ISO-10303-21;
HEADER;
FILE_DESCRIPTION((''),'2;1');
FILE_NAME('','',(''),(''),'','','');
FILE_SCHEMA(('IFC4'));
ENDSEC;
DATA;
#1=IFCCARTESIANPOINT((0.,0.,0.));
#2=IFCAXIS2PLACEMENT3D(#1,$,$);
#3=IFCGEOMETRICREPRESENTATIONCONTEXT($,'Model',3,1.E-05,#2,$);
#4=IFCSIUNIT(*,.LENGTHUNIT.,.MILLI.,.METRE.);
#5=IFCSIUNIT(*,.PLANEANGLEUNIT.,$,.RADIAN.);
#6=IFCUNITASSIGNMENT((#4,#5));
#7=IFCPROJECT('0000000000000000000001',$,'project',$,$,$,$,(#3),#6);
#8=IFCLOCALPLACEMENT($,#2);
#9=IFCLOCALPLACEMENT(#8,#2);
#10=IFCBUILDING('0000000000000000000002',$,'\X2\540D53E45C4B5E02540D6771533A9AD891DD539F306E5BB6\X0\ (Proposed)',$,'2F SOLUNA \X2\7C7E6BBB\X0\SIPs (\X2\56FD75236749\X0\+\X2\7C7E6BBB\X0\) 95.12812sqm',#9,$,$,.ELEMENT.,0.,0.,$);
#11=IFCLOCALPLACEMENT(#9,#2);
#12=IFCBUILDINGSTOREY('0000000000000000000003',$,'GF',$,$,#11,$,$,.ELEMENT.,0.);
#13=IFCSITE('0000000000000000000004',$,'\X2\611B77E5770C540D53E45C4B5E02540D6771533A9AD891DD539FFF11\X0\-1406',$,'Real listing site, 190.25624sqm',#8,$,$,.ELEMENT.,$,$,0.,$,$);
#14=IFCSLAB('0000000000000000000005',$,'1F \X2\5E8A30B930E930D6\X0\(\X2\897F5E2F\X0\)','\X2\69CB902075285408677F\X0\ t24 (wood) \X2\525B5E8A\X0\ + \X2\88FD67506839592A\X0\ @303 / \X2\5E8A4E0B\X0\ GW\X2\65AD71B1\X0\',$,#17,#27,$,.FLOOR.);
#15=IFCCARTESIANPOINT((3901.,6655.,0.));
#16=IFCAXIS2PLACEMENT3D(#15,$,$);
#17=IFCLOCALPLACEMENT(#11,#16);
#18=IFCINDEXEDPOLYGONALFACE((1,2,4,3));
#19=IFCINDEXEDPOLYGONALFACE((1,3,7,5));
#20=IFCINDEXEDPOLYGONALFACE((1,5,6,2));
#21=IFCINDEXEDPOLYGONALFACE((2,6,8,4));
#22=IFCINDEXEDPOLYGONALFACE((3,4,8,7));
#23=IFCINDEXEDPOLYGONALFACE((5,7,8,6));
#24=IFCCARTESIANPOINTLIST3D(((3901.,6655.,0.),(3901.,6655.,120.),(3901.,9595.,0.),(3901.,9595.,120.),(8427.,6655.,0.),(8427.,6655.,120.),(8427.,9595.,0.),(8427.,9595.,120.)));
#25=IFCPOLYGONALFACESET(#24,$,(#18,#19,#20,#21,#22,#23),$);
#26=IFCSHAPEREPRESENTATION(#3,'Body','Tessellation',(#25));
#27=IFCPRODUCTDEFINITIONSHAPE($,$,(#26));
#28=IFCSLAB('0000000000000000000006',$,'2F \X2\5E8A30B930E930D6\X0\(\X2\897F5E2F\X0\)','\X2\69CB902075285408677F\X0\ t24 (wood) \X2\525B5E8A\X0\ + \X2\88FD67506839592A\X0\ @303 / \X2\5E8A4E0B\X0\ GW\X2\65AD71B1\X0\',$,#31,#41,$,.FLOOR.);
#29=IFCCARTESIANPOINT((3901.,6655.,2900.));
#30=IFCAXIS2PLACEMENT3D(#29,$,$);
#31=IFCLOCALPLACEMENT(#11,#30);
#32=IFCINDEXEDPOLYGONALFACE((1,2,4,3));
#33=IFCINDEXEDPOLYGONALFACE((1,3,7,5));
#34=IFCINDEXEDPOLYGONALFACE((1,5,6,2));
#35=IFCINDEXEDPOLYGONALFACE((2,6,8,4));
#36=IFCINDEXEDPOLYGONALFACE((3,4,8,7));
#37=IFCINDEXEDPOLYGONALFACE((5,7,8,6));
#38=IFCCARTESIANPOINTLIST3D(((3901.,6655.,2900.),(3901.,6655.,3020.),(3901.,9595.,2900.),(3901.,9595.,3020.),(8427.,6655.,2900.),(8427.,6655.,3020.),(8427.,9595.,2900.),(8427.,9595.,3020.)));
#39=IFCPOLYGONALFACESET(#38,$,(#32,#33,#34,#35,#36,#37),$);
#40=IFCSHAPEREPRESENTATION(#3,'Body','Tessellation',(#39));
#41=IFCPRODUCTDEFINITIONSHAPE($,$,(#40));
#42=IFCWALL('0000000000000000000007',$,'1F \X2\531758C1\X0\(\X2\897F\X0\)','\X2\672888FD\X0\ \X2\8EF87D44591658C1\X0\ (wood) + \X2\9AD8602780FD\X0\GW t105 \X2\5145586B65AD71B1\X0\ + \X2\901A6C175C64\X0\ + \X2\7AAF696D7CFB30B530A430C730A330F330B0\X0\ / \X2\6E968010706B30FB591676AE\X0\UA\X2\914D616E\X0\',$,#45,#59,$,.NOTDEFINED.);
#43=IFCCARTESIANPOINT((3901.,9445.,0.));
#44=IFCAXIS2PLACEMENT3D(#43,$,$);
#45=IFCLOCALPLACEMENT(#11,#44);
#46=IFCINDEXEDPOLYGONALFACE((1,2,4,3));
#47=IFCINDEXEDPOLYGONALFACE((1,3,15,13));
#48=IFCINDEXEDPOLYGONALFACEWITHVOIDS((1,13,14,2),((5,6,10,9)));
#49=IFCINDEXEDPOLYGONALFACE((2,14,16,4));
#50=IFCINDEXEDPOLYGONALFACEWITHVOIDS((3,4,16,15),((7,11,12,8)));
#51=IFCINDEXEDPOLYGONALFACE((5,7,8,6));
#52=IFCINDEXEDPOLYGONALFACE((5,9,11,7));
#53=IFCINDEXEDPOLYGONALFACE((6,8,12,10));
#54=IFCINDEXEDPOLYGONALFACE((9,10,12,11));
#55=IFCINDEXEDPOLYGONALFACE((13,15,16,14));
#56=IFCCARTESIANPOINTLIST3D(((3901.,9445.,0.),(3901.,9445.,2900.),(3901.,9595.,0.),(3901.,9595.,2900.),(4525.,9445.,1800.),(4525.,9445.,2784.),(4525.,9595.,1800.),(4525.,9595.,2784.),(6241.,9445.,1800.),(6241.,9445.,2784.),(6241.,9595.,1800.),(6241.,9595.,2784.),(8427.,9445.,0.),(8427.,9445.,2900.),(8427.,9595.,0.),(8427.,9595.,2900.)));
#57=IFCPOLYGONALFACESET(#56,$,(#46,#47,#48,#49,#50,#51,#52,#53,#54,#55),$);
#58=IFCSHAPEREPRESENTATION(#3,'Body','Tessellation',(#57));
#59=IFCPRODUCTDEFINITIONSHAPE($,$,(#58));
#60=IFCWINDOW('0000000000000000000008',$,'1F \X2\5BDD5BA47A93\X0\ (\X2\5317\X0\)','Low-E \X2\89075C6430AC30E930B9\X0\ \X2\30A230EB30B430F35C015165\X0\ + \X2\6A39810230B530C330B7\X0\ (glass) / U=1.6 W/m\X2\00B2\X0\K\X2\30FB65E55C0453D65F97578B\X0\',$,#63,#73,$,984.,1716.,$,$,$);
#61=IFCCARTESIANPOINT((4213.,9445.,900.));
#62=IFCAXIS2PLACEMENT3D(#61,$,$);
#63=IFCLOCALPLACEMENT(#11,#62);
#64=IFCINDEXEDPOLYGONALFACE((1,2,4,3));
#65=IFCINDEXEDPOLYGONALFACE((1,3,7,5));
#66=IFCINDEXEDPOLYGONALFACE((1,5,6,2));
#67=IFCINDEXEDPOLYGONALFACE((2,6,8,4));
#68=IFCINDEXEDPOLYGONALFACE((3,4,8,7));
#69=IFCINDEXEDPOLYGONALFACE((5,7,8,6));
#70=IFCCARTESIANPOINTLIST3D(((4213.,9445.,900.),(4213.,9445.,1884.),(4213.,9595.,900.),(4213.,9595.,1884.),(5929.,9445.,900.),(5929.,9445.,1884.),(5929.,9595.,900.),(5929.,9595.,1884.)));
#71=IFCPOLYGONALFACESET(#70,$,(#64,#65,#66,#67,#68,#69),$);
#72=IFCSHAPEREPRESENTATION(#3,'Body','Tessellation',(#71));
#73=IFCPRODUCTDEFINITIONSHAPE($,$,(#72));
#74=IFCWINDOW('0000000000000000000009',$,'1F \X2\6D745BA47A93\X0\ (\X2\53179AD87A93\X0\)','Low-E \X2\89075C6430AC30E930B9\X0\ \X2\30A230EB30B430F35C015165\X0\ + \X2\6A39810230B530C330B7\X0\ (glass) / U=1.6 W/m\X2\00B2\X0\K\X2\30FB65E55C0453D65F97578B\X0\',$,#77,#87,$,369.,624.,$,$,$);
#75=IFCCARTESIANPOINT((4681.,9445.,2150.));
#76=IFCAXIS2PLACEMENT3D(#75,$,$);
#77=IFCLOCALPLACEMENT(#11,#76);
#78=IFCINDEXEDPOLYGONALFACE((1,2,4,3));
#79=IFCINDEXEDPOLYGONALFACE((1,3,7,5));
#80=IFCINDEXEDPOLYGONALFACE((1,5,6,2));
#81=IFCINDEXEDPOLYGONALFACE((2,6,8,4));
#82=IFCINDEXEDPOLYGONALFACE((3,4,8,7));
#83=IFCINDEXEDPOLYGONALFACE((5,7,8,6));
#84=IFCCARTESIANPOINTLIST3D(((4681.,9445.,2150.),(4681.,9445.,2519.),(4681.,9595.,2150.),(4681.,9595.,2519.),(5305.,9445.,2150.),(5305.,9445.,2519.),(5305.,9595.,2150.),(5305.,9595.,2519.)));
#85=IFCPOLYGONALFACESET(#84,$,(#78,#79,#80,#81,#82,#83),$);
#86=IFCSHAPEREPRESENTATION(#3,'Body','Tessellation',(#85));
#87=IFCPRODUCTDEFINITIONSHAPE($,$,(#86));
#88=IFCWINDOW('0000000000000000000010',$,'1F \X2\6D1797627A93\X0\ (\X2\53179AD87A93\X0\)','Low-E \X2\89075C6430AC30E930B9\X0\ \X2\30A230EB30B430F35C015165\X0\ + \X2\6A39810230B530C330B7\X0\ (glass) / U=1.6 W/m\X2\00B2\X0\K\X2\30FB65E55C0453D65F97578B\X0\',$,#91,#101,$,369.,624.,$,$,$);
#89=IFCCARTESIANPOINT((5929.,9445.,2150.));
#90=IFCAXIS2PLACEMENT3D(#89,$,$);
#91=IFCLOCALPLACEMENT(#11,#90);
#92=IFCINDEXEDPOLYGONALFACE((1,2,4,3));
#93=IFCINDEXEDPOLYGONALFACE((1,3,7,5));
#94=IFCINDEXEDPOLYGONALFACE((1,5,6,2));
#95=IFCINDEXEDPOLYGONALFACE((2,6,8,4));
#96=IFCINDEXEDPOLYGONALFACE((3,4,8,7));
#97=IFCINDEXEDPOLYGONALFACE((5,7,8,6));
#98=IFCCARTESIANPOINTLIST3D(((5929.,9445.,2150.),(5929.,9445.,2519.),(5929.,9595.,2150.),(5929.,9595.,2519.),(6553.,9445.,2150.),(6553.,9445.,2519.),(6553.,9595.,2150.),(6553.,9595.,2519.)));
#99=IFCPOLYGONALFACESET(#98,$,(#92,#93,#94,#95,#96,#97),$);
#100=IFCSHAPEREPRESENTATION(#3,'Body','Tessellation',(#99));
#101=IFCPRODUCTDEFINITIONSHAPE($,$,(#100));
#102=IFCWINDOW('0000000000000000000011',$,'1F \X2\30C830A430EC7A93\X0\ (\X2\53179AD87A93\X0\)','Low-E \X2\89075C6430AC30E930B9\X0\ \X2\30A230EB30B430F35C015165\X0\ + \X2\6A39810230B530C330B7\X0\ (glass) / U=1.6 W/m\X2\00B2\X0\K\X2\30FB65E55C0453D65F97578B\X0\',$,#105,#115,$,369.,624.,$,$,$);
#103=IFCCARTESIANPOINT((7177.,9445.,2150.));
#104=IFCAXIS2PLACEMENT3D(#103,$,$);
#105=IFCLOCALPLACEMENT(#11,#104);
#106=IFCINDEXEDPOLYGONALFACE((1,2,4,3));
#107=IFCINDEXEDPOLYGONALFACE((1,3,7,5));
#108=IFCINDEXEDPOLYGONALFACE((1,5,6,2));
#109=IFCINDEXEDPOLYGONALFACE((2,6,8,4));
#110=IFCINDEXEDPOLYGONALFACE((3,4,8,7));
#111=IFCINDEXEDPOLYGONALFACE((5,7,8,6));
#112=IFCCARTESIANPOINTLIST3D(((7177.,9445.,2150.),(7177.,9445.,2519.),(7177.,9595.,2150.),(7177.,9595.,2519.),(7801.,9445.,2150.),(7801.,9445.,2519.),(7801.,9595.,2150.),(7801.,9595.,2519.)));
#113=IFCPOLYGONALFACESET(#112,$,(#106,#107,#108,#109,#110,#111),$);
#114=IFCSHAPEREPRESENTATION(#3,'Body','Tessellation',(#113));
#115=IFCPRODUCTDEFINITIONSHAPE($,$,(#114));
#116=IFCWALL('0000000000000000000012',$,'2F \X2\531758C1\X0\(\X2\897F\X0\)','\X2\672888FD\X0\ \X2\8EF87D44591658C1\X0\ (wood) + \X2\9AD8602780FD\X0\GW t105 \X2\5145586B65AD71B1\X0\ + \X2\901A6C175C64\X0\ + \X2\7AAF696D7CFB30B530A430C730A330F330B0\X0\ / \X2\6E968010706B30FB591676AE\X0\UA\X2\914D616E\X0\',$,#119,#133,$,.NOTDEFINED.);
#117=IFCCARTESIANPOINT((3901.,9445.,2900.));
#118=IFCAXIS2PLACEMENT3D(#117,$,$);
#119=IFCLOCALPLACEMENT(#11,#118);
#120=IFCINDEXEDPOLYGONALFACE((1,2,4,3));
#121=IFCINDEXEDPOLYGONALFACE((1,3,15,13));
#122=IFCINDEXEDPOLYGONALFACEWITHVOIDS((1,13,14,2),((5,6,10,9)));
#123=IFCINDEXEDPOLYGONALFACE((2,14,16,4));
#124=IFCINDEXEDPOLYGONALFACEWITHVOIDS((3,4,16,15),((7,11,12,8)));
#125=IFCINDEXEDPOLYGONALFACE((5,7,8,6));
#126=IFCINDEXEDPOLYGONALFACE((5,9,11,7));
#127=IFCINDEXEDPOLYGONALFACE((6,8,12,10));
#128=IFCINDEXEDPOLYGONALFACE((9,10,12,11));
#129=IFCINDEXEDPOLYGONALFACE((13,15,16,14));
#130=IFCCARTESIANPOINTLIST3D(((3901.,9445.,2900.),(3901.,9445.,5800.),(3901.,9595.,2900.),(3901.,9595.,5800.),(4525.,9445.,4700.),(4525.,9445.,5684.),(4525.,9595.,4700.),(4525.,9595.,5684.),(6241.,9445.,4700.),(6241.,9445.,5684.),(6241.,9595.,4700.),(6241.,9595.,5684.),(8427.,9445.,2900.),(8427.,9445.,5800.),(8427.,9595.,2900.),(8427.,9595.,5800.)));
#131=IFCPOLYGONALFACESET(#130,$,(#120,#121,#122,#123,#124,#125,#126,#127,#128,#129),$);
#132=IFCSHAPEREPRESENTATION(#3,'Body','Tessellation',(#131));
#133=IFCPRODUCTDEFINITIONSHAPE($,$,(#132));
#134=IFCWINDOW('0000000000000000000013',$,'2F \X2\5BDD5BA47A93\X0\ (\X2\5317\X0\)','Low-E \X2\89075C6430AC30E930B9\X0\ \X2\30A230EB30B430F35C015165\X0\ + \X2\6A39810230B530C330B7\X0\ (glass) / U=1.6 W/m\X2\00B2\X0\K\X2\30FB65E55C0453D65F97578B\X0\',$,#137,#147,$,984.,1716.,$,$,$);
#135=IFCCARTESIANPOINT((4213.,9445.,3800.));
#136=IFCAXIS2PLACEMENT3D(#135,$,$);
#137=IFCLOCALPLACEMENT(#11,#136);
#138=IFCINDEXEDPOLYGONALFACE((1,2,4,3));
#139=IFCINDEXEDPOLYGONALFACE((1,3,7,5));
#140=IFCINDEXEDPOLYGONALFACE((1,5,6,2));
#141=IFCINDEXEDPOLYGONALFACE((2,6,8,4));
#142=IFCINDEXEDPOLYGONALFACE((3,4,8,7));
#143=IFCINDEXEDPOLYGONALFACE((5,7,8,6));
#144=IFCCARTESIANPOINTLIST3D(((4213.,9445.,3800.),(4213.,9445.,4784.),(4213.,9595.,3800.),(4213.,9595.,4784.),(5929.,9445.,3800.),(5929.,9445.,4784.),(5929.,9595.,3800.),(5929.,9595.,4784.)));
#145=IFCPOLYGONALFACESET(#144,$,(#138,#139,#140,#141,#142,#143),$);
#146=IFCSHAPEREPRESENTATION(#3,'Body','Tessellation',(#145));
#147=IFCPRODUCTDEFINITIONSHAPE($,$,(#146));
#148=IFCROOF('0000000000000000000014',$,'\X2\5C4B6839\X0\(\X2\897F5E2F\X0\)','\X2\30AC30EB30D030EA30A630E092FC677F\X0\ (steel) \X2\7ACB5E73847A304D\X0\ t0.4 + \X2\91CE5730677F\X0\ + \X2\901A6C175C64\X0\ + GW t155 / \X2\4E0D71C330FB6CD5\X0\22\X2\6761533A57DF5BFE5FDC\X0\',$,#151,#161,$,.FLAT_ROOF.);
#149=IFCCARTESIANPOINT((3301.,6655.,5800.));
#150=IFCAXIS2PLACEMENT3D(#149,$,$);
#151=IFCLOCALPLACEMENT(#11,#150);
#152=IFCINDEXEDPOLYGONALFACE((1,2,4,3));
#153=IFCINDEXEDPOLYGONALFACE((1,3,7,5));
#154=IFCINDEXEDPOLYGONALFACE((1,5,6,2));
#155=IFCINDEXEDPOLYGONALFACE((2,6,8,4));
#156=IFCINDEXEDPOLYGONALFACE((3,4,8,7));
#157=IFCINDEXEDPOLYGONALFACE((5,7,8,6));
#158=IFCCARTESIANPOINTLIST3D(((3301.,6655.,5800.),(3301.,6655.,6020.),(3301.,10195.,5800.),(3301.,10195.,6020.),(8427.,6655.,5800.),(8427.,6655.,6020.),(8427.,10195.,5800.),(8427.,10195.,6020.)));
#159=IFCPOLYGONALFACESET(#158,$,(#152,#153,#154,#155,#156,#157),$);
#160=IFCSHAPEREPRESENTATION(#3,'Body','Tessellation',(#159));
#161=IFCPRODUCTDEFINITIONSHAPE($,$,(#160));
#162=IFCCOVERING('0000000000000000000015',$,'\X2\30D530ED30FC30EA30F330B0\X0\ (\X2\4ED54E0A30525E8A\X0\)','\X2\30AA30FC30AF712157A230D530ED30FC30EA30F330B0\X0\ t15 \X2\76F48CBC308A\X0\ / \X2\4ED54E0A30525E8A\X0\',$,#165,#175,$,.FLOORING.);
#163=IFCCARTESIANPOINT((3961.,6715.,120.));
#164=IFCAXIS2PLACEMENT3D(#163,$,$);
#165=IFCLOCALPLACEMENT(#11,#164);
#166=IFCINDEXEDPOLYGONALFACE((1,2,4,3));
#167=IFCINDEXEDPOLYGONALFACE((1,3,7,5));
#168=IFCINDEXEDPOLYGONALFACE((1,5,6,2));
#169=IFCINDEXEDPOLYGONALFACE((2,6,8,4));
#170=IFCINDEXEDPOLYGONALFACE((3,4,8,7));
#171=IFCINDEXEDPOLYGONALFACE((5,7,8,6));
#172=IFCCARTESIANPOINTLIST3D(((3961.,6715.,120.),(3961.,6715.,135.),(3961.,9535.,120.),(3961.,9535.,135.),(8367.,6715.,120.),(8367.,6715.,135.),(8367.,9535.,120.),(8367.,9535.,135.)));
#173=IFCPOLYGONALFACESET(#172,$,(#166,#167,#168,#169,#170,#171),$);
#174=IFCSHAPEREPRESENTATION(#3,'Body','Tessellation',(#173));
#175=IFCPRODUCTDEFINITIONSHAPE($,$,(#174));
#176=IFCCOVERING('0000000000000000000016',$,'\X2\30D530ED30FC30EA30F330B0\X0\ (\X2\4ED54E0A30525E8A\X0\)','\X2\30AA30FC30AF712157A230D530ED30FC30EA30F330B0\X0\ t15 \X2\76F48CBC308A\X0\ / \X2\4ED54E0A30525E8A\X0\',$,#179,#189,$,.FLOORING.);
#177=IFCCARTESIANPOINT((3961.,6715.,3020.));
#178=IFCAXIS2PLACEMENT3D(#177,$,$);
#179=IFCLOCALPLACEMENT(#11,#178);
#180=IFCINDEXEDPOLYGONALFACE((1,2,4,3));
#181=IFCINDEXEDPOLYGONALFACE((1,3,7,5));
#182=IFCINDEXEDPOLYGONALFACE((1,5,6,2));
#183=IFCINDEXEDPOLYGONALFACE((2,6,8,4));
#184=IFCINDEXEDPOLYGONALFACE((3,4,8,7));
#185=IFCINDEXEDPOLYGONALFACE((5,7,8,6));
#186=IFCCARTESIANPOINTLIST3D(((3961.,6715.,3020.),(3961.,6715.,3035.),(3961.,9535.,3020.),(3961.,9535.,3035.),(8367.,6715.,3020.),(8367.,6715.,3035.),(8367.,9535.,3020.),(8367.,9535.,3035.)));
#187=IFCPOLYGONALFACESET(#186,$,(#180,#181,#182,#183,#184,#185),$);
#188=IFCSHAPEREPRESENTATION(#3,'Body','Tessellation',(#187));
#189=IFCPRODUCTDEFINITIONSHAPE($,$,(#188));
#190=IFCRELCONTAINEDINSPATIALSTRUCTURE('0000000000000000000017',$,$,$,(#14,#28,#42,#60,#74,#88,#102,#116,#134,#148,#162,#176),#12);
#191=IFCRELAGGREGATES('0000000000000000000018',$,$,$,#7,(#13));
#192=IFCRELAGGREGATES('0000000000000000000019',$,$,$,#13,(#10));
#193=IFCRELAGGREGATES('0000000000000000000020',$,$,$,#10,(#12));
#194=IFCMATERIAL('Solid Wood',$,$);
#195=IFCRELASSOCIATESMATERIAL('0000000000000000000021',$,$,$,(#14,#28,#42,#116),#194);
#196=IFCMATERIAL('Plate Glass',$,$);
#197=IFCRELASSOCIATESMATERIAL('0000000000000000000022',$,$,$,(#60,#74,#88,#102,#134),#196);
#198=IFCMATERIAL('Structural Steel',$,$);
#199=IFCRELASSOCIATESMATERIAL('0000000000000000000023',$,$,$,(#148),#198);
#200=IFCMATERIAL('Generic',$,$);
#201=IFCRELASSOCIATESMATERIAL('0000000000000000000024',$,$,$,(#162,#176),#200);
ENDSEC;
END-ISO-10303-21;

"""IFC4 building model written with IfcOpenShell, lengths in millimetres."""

from ifc_helpers import new_model, si_unit, frame, frame_2d, origin, place, context, project, spatial, rectangle, extrude, material, element, fill, save


model = new_model("IFC4")

# Units and contexts
model_context = context("Model", 3, precision=1e-05, world=origin())
ifc_project = project(units=[si_unit("LENGTHUNIT", "METRE", prefix="MILLI"), si_unit("PLANEANGLEUNIT", "RADIAN")], contexts=[model_context])

# Site, building, storey
site_placement = place(None, origin())
site = spatial("IfcSite", under=ifc_project, at=site_placement, Name="愛知県名古屋市名東区高針原１-1406", ObjectType="Real listing site, 190.25624sqm", CompositionType="ELEMENT", RefElevation=0.0)
building_placement = place(site_placement, origin())
building = spatial("IfcBuilding", under=site, at=building_placement, Name="名古屋市名東区高針原の家 (Proposed)", ObjectType="2F SOLUNA 籾殻SIPs (国産杉+籾殻) 95.12812sqm", CompositionType="ELEMENT", ElevationOfRefHeight=0.0, ElevationOfTerrain=0.0)
storey_placement = place(building_placement, origin())
storey = spatial("IfcBuildingStorey", under=building, at=storey_placement, Name="GF", CompositionType="ELEMENT", Elevation=0.0)

# Slabs
ifc_material_1 = material(Name="Solid Wood")
slab_1_placement = place(storey_placement, frame((3901.0, 6655.0, 0.0)))
element("IfcSlab", 1, at=slab_1_placement, inside=storey, material=ifc_material_1, Name="1F 床スラブ(西帯)", Description="構造用合板 t24 (wood) 剛床 + 製材根太 @303 / 床下 GW断熱", PredefinedType="FLOOR", context=model_context, shape_type="SweptSolid", body=[
    extrude(rectangle(XDim=4526.0, YDim=2940.0, at=frame_2d((2263.0, 1470.0))), frame((3901.0, 6655.0, 0.0)), (0.0, 0.0, 1.0), 120.0),
])
slab_2_placement = place(storey_placement, frame((3901.0, 6655.0, 2900.0)))
element("IfcSlab", 2, at=slab_2_placement, inside=storey, material=ifc_material_1, Name="2F 床スラブ(西帯)", Description="構造用合板 t24 (wood) 剛床 + 製材根太 @303 / 床下 GW断熱", PredefinedType="FLOOR", context=model_context, shape_type="SweptSolid", body=[
    extrude(rectangle(XDim=4526.0, YDim=2940.0, at=frame_2d((2263.0, 1470.0))), frame((3901.0, 6655.0, 2900.0)), (0.0, 0.0, 1.0), 120.0),
])

# Wall, openings, windows
wall_1_placement = place(storey_placement, frame((3901.0, 9445.0, 0.0)))
wall_1 = element("IfcWall", 3, at=wall_1_placement, inside=storey, material=ifc_material_1, Name="1F 北壁(西)", Description="木製 軸組外壁 (wood) + 高性能GW t105 充填断熱 + 通気層 + 窯業系サイディング / 準耐火・外皮UA配慮", PredefinedType="NOTDEFINED", context=model_context, shape_type="SweptSolid", body=[
    extrude(rectangle(XDim=4526.0, YDim=150.0, at=frame_2d((2263.0, 75.0))), frame((3901.0, 9445.0, 0.0)), (0.0, 0.0, 1.0), 2900.0),
])
opening_1_placement = place(storey_placement, frame((4213.0, 9445.0, 900.0)))
opening_1 = element("IfcOpeningElement", 4, at=opening_1_placement, cuts=wall_1, PredefinedType="NOTDEFINED", context=model_context, shape_type="SweptSolid", body=[
    extrude(rectangle(XDim=1716.0, YDim=150.0, at=frame_2d((858.0, 75.0))), frame((4213.0, 9445.0, 900.0)), (0.0, 0.0, 1.0), 984.0),
])
opening_2_placement = place(storey_placement, frame((4681.0, 9445.0, 2150.0)))
opening_2 = element("IfcOpeningElement", 5, at=opening_2_placement, cuts=wall_1, PredefinedType="NOTDEFINED", context=model_context, shape_type="SweptSolid", body=[
    extrude(rectangle(XDim=624.0, YDim=150.0, at=frame_2d((312.0, 75.0))), frame((4681.0, 9445.0, 2150.0)), (0.0, 0.0, 1.0), 369.0),
])
opening_3_placement = place(storey_placement, frame((5929.0, 9445.0, 2150.0)))
opening_3 = element("IfcOpeningElement", 6, at=opening_3_placement, cuts=wall_1, PredefinedType="NOTDEFINED", context=model_context, shape_type="SweptSolid", body=[
    extrude(rectangle(XDim=624.0, YDim=150.0, at=frame_2d((312.0, 75.0))), frame((5929.0, 9445.0, 2150.0)), (0.0, 0.0, 1.0), 369.0),
])
opening_4_placement = place(storey_placement, frame((7177.0, 9445.0, 2150.0)))
opening_4 = element("IfcOpeningElement", 7, at=opening_4_placement, cuts=wall_1, PredefinedType="NOTDEFINED", context=model_context, shape_type="SweptSolid", body=[
    extrude(rectangle(XDim=624.0, YDim=150.0, at=frame_2d((312.0, 75.0))), frame((7177.0, 9445.0, 2150.0)), (0.0, 0.0, 1.0), 369.0),
])
ifc_material_2 = material(Name="Plate Glass")
window_1_placement = place(storey_placement, frame((4213.0, 9445.0, 900.0)))
window_1 = element("IfcWindow", 8, at=window_1_placement, inside=storey, material=ifc_material_2, Name="1F 寝室窓 (北)", Description="Low-E 複層ガラス アルゴン封入 + 樹脂サッシ (glass) / U=1.6 W/m²K・日射取得型", OverallHeight=984.0, OverallWidth=1716.0, context=model_context, shape_type="SweptSolid", body=[
    extrude(rectangle(XDim=1716.0, YDim=150.0, at=frame_2d((858.0, 75.0))), frame((4213.0, 9445.0, 900.0)), (0.0, 0.0, 1.0), 984.0),
])
fill(opening_1, window_1)
window_2_placement = place(storey_placement, frame((4681.0, 9445.0, 2150.0)))
window_2 = element("IfcWindow", 9, at=window_2_placement, inside=storey, material=ifc_material_2, Name="1F 浴室窓 (北高窓)", Description="Low-E 複層ガラス アルゴン封入 + 樹脂サッシ (glass) / U=1.6 W/m²K・日射取得型", OverallHeight=369.0, OverallWidth=624.0, context=model_context, shape_type="SweptSolid", body=[
    extrude(rectangle(XDim=624.0, YDim=150.0, at=frame_2d((312.0, 75.0))), frame((4681.0, 9445.0, 2150.0)), (0.0, 0.0, 1.0), 369.0),
])
fill(opening_2, window_2)
window_3_placement = place(storey_placement, frame((5929.0, 9445.0, 2150.0)))
window_3 = element("IfcWindow", 10, at=window_3_placement, inside=storey, material=ifc_material_2, Name="1F 洗面窓 (北高窓)", Description="Low-E 複層ガラス アルゴン封入 + 樹脂サッシ (glass) / U=1.6 W/m²K・日射取得型", OverallHeight=369.0, OverallWidth=624.0, context=model_context, shape_type="SweptSolid", body=[
    extrude(rectangle(XDim=624.0, YDim=150.0, at=frame_2d((312.0, 75.0))), frame((5929.0, 9445.0, 2150.0)), (0.0, 0.0, 1.0), 369.0),
])
fill(opening_3, window_3)
window_4_placement = place(storey_placement, frame((7177.0, 9445.0, 2150.0)))
window_4 = element("IfcWindow", 11, at=window_4_placement, inside=storey, material=ifc_material_2, Name="1F トイレ窓 (北高窓)", Description="Low-E 複層ガラス アルゴン封入 + 樹脂サッシ (glass) / U=1.6 W/m²K・日射取得型", OverallHeight=369.0, OverallWidth=624.0, context=model_context, shape_type="SweptSolid", body=[
    extrude(rectangle(XDim=624.0, YDim=150.0, at=frame_2d((312.0, 75.0))), frame((7177.0, 9445.0, 2150.0)), (0.0, 0.0, 1.0), 369.0),
])
fill(opening_4, window_4)

# Wall, opening, window
wall_2_placement = place(storey_placement, frame((3901.0, 9445.0, 2900.0)))
wall_2 = element("IfcWall", 12, at=wall_2_placement, inside=storey, material=ifc_material_1, Name="2F 北壁(西)", Description="木製 軸組外壁 (wood) + 高性能GW t105 充填断熱 + 通気層 + 窯業系サイディング / 準耐火・外皮UA配慮", PredefinedType="NOTDEFINED", context=model_context, shape_type="SweptSolid", body=[
    extrude(rectangle(XDim=4526.0, YDim=150.0, at=frame_2d((2263.0, 75.0))), frame((3901.0, 9445.0, 2900.0)), (0.0, 0.0, 1.0), 2900.0),
])
opening_5_placement = place(storey_placement, frame((4213.0, 9445.0, 3800.0)))
opening_5 = element("IfcOpeningElement", 13, at=opening_5_placement, cuts=wall_2, PredefinedType="NOTDEFINED", context=model_context, shape_type="SweptSolid", body=[
    extrude(rectangle(XDim=1716.0, YDim=150.0, at=frame_2d((858.0, 75.0))), frame((4213.0, 9445.0, 3800.0)), (0.0, 0.0, 1.0), 984.0),
])
window_5_placement = place(storey_placement, frame((4213.0, 9445.0, 3800.0)))
window_5 = element("IfcWindow", 14, at=window_5_placement, inside=storey, material=ifc_material_2, Name="2F 寝室窓 (北)", Description="Low-E 複層ガラス アルゴン封入 + 樹脂サッシ (glass) / U=1.6 W/m²K・日射取得型", OverallHeight=984.0, OverallWidth=1716.0, context=model_context, shape_type="SweptSolid", body=[
    extrude(rectangle(XDim=1716.0, YDim=150.0, at=frame_2d((858.0, 75.0))), frame((4213.0, 9445.0, 3800.0)), (0.0, 0.0, 1.0), 984.0),
])
fill(opening_5, window_5)

# Roof
ifc_material_3 = material(Name="Structural Steel")
for number, where, name in (
    (15, (3301.0, 6655.0, 5800.0), "屋根(西帯)"),
):
    element("IfcRoof", number, at=place(storey_placement, frame(where)), inside=storey, material=ifc_material_3, Name=name, Description="ガルバリウム鋼板 (steel) 立平葺き t0.4 + 野地板 + 通気層 + GW t155 / 不燃・法22条区域対応", PredefinedType="FLAT_ROOF", context=model_context, shape_type="SweptSolid", body=[
        extrude(rectangle(XDim=5126.0, YDim=3540.0, at=frame_2d((2563.0, 1770.0))), frame((3301.0, 6655.0, 5800.0)), (0.0, 0.0, 1.0), 220.0),
    ])

# Coverings
ifc_material_4 = material(Name="Generic")
covering_1_placement = place(storey_placement, frame((3961.0, 6715.0, 120.0)))
element("IfcCovering", 16, at=covering_1_placement, inside=storey, material=ifc_material_4, Name="フローリング (仕上げ床)", Description="オーク無垢フローリング t15 直貼り / 仕上げ床", PredefinedType="FLOORING", context=model_context, shape_type="SweptSolid", body=[
    extrude(rectangle(XDim=4406.0, YDim=2820.0, at=frame_2d((2203.0, 1410.0))), frame((3961.0, 6715.0, 120.0)), (0.0, 0.0, 1.0), 15.0),
])
covering_2_placement = place(storey_placement, frame((3961.0, 6715.0, 3020.0)))
element("IfcCovering", 17, at=covering_2_placement, inside=storey, material=ifc_material_4, Name="フローリング (仕上げ床)", Description="オーク無垢フローリング t15 直貼り / 仕上げ床", PredefinedType="FLOORING", context=model_context, shape_type="SweptSolid", body=[
    extrude(rectangle(XDim=4406.0, YDim=2820.0, at=frame_2d((2203.0, 1410.0))), frame((3961.0, 6715.0, 3020.0)), (0.0, 0.0, 1.0), 15.0),
])

save(model, "model.ifc")
